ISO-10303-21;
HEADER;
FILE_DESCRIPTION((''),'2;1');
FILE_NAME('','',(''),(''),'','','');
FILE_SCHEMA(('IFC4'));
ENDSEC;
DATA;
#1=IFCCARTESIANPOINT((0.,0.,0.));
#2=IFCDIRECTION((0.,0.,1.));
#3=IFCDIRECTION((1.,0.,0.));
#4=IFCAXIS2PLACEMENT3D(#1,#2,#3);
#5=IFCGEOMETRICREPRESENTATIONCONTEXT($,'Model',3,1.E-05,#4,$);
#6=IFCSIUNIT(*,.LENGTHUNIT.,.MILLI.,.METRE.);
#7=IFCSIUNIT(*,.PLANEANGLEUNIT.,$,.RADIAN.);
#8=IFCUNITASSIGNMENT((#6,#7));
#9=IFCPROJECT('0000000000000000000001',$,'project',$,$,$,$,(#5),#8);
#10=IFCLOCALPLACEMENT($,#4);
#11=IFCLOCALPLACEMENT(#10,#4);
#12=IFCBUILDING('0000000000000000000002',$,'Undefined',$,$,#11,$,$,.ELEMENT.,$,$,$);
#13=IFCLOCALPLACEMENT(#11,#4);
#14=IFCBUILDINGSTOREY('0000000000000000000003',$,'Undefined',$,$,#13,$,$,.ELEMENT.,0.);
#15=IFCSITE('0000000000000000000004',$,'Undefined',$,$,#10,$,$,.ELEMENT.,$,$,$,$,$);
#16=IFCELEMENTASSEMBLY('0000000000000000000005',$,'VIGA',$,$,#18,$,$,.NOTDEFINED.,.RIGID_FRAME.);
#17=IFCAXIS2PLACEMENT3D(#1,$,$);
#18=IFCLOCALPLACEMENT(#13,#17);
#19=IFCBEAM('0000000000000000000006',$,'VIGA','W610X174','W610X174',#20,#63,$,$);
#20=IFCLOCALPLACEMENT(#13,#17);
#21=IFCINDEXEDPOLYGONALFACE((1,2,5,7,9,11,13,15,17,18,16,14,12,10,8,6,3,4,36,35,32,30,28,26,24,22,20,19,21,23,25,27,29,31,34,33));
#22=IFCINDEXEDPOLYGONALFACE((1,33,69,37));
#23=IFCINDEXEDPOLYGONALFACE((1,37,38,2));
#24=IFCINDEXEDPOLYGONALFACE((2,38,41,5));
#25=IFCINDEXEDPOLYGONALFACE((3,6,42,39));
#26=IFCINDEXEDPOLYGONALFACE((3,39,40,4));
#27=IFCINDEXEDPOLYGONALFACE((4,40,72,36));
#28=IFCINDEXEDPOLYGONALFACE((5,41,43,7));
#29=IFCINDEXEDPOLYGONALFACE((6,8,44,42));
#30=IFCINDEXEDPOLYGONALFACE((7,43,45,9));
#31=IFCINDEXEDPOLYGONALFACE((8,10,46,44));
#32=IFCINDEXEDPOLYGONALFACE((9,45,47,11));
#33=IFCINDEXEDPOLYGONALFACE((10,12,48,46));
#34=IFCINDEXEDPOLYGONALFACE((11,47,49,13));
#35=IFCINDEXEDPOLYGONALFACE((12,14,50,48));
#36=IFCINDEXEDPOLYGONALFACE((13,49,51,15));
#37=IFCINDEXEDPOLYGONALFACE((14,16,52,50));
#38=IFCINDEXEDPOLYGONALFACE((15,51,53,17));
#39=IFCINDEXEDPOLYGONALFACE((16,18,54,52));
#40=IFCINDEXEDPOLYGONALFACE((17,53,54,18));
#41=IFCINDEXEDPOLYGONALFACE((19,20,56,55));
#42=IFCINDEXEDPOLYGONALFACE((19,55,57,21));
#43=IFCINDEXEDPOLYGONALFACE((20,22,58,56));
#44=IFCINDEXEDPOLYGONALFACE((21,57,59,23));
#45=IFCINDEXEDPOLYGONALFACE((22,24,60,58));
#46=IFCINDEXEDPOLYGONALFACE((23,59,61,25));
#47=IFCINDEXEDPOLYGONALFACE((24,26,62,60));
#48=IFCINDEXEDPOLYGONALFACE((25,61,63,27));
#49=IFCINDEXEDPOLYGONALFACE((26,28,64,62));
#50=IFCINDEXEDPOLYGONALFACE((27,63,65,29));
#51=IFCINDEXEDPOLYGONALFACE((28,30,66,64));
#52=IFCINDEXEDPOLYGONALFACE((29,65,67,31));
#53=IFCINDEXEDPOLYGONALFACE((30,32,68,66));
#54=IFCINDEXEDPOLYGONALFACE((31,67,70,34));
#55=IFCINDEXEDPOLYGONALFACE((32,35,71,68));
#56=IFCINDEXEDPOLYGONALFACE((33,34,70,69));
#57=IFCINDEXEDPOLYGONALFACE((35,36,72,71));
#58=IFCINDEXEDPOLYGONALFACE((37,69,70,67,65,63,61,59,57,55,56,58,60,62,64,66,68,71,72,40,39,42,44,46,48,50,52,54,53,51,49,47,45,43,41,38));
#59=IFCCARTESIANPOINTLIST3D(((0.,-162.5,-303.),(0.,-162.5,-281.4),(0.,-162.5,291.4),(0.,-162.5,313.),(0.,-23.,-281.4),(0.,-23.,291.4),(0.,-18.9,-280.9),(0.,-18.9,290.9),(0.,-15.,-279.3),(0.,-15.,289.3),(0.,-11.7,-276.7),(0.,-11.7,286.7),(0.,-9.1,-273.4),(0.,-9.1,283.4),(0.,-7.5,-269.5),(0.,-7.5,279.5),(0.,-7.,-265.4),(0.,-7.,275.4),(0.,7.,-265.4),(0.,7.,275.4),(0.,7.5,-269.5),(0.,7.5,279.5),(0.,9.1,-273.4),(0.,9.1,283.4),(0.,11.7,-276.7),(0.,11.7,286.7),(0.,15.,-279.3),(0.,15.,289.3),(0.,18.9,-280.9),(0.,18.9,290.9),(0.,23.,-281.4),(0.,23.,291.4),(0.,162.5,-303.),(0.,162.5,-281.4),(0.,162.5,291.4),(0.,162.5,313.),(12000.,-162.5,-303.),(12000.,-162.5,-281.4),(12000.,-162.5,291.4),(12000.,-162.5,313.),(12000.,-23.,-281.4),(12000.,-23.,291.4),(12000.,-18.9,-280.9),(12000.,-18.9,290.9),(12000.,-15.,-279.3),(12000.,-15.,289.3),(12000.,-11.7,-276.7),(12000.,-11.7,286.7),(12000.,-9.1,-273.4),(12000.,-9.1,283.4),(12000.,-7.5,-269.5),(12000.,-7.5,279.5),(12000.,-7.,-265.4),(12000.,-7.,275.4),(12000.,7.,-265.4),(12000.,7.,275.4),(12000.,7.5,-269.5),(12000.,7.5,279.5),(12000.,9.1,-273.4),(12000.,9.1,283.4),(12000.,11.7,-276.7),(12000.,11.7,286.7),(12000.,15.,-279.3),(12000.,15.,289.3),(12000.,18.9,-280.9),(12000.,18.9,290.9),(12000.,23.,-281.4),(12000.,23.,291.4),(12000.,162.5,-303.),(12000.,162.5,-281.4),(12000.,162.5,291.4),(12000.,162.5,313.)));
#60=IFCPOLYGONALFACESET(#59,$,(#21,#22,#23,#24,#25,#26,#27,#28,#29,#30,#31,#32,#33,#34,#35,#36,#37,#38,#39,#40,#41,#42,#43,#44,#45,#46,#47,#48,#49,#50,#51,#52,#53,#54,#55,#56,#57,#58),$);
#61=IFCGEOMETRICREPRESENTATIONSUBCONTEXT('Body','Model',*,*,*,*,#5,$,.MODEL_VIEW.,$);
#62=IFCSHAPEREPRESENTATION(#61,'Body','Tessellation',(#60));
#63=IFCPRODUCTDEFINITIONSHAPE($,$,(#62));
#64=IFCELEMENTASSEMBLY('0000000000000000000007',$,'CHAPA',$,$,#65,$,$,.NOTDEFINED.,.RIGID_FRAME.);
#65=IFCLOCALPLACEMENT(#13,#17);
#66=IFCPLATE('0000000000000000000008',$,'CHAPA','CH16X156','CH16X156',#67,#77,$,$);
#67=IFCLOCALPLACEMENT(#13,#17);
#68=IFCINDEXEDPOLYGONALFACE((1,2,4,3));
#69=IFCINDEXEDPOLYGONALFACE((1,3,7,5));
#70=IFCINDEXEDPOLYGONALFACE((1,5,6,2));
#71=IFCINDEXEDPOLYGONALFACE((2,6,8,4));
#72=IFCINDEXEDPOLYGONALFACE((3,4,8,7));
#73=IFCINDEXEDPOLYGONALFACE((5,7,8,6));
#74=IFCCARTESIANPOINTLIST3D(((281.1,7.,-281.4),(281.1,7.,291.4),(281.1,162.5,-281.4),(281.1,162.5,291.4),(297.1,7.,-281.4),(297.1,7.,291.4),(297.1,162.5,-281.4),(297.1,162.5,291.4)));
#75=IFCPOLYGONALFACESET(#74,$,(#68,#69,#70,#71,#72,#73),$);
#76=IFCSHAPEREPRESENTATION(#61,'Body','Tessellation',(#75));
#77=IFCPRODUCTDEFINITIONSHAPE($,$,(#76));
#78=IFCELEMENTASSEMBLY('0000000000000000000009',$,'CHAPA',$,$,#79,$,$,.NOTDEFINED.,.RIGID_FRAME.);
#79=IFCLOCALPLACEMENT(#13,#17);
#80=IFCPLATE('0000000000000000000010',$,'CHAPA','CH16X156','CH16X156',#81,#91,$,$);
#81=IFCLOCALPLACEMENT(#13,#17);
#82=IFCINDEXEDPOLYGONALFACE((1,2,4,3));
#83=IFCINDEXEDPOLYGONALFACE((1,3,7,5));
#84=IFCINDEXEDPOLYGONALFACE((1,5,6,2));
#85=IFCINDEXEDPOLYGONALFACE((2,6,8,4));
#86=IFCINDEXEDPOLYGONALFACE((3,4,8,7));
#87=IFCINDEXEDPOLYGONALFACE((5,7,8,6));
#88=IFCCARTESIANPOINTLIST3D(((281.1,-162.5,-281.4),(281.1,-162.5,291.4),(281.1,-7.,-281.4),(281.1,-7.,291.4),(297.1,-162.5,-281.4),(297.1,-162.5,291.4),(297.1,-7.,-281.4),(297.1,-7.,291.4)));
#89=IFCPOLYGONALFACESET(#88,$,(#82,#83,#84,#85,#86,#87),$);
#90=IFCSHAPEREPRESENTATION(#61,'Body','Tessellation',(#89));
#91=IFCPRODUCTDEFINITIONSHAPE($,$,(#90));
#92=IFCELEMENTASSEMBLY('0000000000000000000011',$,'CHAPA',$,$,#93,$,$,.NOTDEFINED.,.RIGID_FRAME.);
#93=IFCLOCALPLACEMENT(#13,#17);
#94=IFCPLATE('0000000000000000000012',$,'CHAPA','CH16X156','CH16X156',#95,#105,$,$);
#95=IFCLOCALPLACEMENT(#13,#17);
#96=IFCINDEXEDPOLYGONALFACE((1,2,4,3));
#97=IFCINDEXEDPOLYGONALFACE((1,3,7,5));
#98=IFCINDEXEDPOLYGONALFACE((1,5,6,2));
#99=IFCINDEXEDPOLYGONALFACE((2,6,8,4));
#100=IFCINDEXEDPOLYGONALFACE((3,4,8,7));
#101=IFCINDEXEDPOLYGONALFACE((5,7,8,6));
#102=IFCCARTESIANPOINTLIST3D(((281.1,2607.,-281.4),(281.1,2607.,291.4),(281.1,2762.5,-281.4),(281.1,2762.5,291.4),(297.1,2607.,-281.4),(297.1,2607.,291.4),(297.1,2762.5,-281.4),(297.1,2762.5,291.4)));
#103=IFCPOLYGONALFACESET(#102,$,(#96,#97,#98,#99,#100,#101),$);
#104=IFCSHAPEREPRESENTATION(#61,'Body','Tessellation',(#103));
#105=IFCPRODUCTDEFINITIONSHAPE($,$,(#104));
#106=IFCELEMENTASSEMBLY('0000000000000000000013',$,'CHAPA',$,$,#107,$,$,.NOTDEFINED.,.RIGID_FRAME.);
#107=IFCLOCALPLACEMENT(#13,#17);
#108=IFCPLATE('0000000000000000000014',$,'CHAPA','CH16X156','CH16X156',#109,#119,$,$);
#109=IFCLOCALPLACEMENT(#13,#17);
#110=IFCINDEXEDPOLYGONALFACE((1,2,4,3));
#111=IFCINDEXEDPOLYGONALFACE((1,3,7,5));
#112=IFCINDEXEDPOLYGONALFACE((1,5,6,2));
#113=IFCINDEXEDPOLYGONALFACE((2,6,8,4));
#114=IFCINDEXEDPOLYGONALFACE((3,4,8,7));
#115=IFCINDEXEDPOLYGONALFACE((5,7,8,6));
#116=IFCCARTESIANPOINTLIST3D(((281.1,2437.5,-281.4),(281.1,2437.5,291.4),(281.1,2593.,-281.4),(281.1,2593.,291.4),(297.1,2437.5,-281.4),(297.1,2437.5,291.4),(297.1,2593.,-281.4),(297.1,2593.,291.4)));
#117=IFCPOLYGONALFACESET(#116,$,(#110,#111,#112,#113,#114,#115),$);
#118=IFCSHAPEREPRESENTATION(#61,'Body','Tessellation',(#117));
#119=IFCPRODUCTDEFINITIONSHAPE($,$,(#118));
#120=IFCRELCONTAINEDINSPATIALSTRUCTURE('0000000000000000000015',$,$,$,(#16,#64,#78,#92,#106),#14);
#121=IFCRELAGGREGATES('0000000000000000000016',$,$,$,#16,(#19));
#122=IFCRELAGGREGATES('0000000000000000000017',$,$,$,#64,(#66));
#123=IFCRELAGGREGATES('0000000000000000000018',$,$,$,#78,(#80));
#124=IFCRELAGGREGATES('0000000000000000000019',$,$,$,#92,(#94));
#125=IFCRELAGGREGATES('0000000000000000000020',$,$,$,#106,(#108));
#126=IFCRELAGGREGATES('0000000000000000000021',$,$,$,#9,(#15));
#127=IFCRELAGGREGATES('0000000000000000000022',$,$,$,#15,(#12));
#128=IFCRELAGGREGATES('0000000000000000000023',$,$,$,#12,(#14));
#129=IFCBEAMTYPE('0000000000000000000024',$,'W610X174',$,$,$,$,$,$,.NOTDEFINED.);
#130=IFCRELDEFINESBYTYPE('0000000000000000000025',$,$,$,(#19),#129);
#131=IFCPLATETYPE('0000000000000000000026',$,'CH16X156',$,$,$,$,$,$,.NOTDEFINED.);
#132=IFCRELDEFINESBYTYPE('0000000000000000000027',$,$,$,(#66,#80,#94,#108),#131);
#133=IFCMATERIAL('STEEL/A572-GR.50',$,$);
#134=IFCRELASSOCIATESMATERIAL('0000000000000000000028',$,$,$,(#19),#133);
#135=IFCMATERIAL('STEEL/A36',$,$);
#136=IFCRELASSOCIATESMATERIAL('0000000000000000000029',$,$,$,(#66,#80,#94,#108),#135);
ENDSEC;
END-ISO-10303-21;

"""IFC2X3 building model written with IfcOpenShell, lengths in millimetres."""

from ifc_helpers import new_model, si_unit, frame, origin_with_axes, origin_2d_with_axis, place, context, subcontext, project, spatial, polyline, i_section, outline, extrude, material, type_object, element, aggregate, save


model = new_model("IFC2X3")

# Units and contexts
model_context = context("Model", 3, precision=1e-05, world=origin_with_axes())
body_context = subcontext(model_context, "Body", "Model", "MODEL_VIEW")
ifc_project = project(units=[si_unit("LENGTHUNIT", "METRE", prefix="MILLI"), si_unit("PLANEANGLEUNIT", "RADIAN")], contexts=[model_context])

# Site, building, storey
site_placement = place(None, origin_with_axes())
site = spatial("IfcSite", under=ifc_project, at=site_placement, Name="Undefined", CompositionType="ELEMENT")
building_placement = place(site_placement, origin_with_axes())
building = spatial("IfcBuilding", under=site, at=building_placement, Name="Undefined", CompositionType="ELEMENT")
storey_placement = place(building_placement, origin_with_axes())
storey = spatial("IfcBuildingStorey", under=building, at=storey_placement, Name="Undefined", CompositionType="ELEMENT", Elevation=0.0)

# Element assembly, beam
ifc_material_1 = material(Name="STEEL/A572-GR.50")
beam_type_1 = type_object("IfcBeamType", Name="W610X174", PredefinedType="NOTDEFINED")
assembly_1_placement = place(storey_placement, origin_with_axes())
assembly_1 = element("IfcElementAssembly", 1, at=assembly_1_placement, inside=storey, Name="VIGA", AssemblyPlace="NOTDEFINED", PredefinedType="RIGID_FRAME")
beam_1_placement = place(assembly_1_placement, frame((0.0, 0.0, 5.0), z_axis=(0.0, 0.0, 1.0), x_axis=(1.0, 0.0, 0.0)))
beam_1 = element("IfcBeam", 2, at=beam_1_placement, type_object=beam_type_1, material=ifc_material_1, Name="VIGA", Description="W610X174", ObjectType="W610X174", context=body_context, shape_type="SweptSolid", body=[
    extrude(i_section(OverallWidth=325.0, OverallDepth=616.0, WebThickness=14.0, FlangeThickness=21.6, FilletRadius=16.0, at=origin_2d_with_axis()), frame((12000.0, 0.0, 0.0), z_axis=(-1.0, 0.0, 0.0), x_axis=(0.0, -1.0, 0.0)), (0.0, 0.0, 1.0), 12000.0),
])
aggregate(assembly_1, [beam_1])

# Element assemblies, plates
assembly_2_placement = place(storey_placement, origin_with_axes())
assembly_2 = element("IfcElementAssembly", 3, at=assembly_2_placement, inside=storey, Name="CHAPA", AssemblyPlace="NOTDEFINED", PredefinedType="RIGID_FRAME")
ifc_material_2 = material(Name="STEEL/A36")
plate_type = type_object("IfcPlateType", Name="CH16X156", PredefinedType="NOTDEFINED")
plate_1_placement = place(assembly_2_placement, frame((289.1, 162.5, 291.4), z_axis=(1.0, 0.0, 0.0), x_axis=(0.0, -1.0, 0.0)))
plate_1 = element("IfcPlate", 4, at=plate_1_placement, type_object=plate_type, material=ifc_material_2, Name="CHAPA", Description="CH16X156", ObjectType="CH16X156", context=body_context, shape_type="SweptSolid", body=[
    extrude(outline(polyline([(0.0, 0.0), (155.5, 0.0), (155.5, 572.8), (0.0, 572.8), (0.0, 0.0)])), frame((0.0, 0.0, -8.0), z_axis=(0.0, 0.0, 1.0), x_axis=(1.0, 0.0, 0.0)), (0.0, 0.0, 1.0), 16.0),
])
aggregate(assembly_2, [plate_1])
assembly_3_placement = place(storey_placement, origin_with_axes())
assembly_3 = element("IfcElementAssembly", 5, at=assembly_3_placement, inside=storey, Name="CHAPA", AssemblyPlace="NOTDEFINED", PredefinedType="RIGID_FRAME")
plate_2_placement = place(assembly_3_placement, frame((289.1, -7.0, 291.4), z_axis=(1.0, 0.0, 0.0), x_axis=(0.0, -1.0, 0.0)))
plate_2 = element("IfcPlate", 6, at=plate_2_placement, type_object=plate_type, material=ifc_material_2, Name="CHAPA", Description="CH16X156", ObjectType="CH16X156", context=body_context, shape_type="SweptSolid", body=[
    extrude(outline(polyline([(0.0, 0.0), (155.5, 0.0), (155.5, 572.8), (0.0, 572.8), (0.0, 0.0)])), frame((0.0, 0.0, -8.0), z_axis=(0.0, 0.0, 1.0), x_axis=(1.0, 0.0, 0.0)), (0.0, 0.0, 1.0), 16.0),
])
aggregate(assembly_3, [plate_2])
assembly_4_placement = place(storey_placement, origin_with_axes())
assembly_4 = element("IfcElementAssembly", 7, at=assembly_4_placement, inside=storey, Name="CHAPA", AssemblyPlace="NOTDEFINED", PredefinedType="RIGID_FRAME")
plate_3_placement = place(assembly_4_placement, frame((289.1, 2762.5, 291.4), z_axis=(1.0, 0.0, 0.0), x_axis=(0.0, -1.0, 0.0)))
plate_3 = element("IfcPlate", 8, at=plate_3_placement, type_object=plate_type, material=ifc_material_2, Name="CHAPA", Description="CH16X156", ObjectType="CH16X156", context=body_context, shape_type="SweptSolid", body=[
    extrude(outline(polyline([(0.0, 0.0), (155.5, 0.0), (155.5, 572.8), (0.0, 572.8), (0.0, 0.0)])), frame((0.0, 0.0, -8.0), z_axis=(0.0, 0.0, 1.0), x_axis=(1.0, 0.0, 0.0)), (0.0, 0.0, 1.0), 16.0),
])
aggregate(assembly_4, [plate_3])
assembly_5_placement = place(storey_placement, origin_with_axes())
assembly_5 = element("IfcElementAssembly", 9, at=assembly_5_placement, inside=storey, Name="CHAPA", AssemblyPlace="NOTDEFINED", PredefinedType="RIGID_FRAME")
plate_4_placement = place(assembly_5_placement, frame((289.1, 2593.0, 291.4), z_axis=(1.0, 0.0, 0.0), x_axis=(0.0, -1.0, 0.0)))
plate_4 = element("IfcPlate", 10, at=plate_4_placement, type_object=plate_type, material=ifc_material_2, Name="CHAPA", Description="CH16X156", ObjectType="CH16X156", context=body_context, shape_type="SweptSolid", body=[
    extrude(outline(polyline([(0.0, 0.0), (155.5, 0.0), (155.5, 572.8), (0.0, 572.8), (0.0, 0.0)])), frame((0.0, 0.0, -8.0), z_axis=(0.0, 0.0, 1.0), x_axis=(1.0, 0.0, 0.0)), (0.0, 0.0, 1.0), 16.0),
])
aggregate(assembly_5, [plate_4])

save(model, "model.ifc")
